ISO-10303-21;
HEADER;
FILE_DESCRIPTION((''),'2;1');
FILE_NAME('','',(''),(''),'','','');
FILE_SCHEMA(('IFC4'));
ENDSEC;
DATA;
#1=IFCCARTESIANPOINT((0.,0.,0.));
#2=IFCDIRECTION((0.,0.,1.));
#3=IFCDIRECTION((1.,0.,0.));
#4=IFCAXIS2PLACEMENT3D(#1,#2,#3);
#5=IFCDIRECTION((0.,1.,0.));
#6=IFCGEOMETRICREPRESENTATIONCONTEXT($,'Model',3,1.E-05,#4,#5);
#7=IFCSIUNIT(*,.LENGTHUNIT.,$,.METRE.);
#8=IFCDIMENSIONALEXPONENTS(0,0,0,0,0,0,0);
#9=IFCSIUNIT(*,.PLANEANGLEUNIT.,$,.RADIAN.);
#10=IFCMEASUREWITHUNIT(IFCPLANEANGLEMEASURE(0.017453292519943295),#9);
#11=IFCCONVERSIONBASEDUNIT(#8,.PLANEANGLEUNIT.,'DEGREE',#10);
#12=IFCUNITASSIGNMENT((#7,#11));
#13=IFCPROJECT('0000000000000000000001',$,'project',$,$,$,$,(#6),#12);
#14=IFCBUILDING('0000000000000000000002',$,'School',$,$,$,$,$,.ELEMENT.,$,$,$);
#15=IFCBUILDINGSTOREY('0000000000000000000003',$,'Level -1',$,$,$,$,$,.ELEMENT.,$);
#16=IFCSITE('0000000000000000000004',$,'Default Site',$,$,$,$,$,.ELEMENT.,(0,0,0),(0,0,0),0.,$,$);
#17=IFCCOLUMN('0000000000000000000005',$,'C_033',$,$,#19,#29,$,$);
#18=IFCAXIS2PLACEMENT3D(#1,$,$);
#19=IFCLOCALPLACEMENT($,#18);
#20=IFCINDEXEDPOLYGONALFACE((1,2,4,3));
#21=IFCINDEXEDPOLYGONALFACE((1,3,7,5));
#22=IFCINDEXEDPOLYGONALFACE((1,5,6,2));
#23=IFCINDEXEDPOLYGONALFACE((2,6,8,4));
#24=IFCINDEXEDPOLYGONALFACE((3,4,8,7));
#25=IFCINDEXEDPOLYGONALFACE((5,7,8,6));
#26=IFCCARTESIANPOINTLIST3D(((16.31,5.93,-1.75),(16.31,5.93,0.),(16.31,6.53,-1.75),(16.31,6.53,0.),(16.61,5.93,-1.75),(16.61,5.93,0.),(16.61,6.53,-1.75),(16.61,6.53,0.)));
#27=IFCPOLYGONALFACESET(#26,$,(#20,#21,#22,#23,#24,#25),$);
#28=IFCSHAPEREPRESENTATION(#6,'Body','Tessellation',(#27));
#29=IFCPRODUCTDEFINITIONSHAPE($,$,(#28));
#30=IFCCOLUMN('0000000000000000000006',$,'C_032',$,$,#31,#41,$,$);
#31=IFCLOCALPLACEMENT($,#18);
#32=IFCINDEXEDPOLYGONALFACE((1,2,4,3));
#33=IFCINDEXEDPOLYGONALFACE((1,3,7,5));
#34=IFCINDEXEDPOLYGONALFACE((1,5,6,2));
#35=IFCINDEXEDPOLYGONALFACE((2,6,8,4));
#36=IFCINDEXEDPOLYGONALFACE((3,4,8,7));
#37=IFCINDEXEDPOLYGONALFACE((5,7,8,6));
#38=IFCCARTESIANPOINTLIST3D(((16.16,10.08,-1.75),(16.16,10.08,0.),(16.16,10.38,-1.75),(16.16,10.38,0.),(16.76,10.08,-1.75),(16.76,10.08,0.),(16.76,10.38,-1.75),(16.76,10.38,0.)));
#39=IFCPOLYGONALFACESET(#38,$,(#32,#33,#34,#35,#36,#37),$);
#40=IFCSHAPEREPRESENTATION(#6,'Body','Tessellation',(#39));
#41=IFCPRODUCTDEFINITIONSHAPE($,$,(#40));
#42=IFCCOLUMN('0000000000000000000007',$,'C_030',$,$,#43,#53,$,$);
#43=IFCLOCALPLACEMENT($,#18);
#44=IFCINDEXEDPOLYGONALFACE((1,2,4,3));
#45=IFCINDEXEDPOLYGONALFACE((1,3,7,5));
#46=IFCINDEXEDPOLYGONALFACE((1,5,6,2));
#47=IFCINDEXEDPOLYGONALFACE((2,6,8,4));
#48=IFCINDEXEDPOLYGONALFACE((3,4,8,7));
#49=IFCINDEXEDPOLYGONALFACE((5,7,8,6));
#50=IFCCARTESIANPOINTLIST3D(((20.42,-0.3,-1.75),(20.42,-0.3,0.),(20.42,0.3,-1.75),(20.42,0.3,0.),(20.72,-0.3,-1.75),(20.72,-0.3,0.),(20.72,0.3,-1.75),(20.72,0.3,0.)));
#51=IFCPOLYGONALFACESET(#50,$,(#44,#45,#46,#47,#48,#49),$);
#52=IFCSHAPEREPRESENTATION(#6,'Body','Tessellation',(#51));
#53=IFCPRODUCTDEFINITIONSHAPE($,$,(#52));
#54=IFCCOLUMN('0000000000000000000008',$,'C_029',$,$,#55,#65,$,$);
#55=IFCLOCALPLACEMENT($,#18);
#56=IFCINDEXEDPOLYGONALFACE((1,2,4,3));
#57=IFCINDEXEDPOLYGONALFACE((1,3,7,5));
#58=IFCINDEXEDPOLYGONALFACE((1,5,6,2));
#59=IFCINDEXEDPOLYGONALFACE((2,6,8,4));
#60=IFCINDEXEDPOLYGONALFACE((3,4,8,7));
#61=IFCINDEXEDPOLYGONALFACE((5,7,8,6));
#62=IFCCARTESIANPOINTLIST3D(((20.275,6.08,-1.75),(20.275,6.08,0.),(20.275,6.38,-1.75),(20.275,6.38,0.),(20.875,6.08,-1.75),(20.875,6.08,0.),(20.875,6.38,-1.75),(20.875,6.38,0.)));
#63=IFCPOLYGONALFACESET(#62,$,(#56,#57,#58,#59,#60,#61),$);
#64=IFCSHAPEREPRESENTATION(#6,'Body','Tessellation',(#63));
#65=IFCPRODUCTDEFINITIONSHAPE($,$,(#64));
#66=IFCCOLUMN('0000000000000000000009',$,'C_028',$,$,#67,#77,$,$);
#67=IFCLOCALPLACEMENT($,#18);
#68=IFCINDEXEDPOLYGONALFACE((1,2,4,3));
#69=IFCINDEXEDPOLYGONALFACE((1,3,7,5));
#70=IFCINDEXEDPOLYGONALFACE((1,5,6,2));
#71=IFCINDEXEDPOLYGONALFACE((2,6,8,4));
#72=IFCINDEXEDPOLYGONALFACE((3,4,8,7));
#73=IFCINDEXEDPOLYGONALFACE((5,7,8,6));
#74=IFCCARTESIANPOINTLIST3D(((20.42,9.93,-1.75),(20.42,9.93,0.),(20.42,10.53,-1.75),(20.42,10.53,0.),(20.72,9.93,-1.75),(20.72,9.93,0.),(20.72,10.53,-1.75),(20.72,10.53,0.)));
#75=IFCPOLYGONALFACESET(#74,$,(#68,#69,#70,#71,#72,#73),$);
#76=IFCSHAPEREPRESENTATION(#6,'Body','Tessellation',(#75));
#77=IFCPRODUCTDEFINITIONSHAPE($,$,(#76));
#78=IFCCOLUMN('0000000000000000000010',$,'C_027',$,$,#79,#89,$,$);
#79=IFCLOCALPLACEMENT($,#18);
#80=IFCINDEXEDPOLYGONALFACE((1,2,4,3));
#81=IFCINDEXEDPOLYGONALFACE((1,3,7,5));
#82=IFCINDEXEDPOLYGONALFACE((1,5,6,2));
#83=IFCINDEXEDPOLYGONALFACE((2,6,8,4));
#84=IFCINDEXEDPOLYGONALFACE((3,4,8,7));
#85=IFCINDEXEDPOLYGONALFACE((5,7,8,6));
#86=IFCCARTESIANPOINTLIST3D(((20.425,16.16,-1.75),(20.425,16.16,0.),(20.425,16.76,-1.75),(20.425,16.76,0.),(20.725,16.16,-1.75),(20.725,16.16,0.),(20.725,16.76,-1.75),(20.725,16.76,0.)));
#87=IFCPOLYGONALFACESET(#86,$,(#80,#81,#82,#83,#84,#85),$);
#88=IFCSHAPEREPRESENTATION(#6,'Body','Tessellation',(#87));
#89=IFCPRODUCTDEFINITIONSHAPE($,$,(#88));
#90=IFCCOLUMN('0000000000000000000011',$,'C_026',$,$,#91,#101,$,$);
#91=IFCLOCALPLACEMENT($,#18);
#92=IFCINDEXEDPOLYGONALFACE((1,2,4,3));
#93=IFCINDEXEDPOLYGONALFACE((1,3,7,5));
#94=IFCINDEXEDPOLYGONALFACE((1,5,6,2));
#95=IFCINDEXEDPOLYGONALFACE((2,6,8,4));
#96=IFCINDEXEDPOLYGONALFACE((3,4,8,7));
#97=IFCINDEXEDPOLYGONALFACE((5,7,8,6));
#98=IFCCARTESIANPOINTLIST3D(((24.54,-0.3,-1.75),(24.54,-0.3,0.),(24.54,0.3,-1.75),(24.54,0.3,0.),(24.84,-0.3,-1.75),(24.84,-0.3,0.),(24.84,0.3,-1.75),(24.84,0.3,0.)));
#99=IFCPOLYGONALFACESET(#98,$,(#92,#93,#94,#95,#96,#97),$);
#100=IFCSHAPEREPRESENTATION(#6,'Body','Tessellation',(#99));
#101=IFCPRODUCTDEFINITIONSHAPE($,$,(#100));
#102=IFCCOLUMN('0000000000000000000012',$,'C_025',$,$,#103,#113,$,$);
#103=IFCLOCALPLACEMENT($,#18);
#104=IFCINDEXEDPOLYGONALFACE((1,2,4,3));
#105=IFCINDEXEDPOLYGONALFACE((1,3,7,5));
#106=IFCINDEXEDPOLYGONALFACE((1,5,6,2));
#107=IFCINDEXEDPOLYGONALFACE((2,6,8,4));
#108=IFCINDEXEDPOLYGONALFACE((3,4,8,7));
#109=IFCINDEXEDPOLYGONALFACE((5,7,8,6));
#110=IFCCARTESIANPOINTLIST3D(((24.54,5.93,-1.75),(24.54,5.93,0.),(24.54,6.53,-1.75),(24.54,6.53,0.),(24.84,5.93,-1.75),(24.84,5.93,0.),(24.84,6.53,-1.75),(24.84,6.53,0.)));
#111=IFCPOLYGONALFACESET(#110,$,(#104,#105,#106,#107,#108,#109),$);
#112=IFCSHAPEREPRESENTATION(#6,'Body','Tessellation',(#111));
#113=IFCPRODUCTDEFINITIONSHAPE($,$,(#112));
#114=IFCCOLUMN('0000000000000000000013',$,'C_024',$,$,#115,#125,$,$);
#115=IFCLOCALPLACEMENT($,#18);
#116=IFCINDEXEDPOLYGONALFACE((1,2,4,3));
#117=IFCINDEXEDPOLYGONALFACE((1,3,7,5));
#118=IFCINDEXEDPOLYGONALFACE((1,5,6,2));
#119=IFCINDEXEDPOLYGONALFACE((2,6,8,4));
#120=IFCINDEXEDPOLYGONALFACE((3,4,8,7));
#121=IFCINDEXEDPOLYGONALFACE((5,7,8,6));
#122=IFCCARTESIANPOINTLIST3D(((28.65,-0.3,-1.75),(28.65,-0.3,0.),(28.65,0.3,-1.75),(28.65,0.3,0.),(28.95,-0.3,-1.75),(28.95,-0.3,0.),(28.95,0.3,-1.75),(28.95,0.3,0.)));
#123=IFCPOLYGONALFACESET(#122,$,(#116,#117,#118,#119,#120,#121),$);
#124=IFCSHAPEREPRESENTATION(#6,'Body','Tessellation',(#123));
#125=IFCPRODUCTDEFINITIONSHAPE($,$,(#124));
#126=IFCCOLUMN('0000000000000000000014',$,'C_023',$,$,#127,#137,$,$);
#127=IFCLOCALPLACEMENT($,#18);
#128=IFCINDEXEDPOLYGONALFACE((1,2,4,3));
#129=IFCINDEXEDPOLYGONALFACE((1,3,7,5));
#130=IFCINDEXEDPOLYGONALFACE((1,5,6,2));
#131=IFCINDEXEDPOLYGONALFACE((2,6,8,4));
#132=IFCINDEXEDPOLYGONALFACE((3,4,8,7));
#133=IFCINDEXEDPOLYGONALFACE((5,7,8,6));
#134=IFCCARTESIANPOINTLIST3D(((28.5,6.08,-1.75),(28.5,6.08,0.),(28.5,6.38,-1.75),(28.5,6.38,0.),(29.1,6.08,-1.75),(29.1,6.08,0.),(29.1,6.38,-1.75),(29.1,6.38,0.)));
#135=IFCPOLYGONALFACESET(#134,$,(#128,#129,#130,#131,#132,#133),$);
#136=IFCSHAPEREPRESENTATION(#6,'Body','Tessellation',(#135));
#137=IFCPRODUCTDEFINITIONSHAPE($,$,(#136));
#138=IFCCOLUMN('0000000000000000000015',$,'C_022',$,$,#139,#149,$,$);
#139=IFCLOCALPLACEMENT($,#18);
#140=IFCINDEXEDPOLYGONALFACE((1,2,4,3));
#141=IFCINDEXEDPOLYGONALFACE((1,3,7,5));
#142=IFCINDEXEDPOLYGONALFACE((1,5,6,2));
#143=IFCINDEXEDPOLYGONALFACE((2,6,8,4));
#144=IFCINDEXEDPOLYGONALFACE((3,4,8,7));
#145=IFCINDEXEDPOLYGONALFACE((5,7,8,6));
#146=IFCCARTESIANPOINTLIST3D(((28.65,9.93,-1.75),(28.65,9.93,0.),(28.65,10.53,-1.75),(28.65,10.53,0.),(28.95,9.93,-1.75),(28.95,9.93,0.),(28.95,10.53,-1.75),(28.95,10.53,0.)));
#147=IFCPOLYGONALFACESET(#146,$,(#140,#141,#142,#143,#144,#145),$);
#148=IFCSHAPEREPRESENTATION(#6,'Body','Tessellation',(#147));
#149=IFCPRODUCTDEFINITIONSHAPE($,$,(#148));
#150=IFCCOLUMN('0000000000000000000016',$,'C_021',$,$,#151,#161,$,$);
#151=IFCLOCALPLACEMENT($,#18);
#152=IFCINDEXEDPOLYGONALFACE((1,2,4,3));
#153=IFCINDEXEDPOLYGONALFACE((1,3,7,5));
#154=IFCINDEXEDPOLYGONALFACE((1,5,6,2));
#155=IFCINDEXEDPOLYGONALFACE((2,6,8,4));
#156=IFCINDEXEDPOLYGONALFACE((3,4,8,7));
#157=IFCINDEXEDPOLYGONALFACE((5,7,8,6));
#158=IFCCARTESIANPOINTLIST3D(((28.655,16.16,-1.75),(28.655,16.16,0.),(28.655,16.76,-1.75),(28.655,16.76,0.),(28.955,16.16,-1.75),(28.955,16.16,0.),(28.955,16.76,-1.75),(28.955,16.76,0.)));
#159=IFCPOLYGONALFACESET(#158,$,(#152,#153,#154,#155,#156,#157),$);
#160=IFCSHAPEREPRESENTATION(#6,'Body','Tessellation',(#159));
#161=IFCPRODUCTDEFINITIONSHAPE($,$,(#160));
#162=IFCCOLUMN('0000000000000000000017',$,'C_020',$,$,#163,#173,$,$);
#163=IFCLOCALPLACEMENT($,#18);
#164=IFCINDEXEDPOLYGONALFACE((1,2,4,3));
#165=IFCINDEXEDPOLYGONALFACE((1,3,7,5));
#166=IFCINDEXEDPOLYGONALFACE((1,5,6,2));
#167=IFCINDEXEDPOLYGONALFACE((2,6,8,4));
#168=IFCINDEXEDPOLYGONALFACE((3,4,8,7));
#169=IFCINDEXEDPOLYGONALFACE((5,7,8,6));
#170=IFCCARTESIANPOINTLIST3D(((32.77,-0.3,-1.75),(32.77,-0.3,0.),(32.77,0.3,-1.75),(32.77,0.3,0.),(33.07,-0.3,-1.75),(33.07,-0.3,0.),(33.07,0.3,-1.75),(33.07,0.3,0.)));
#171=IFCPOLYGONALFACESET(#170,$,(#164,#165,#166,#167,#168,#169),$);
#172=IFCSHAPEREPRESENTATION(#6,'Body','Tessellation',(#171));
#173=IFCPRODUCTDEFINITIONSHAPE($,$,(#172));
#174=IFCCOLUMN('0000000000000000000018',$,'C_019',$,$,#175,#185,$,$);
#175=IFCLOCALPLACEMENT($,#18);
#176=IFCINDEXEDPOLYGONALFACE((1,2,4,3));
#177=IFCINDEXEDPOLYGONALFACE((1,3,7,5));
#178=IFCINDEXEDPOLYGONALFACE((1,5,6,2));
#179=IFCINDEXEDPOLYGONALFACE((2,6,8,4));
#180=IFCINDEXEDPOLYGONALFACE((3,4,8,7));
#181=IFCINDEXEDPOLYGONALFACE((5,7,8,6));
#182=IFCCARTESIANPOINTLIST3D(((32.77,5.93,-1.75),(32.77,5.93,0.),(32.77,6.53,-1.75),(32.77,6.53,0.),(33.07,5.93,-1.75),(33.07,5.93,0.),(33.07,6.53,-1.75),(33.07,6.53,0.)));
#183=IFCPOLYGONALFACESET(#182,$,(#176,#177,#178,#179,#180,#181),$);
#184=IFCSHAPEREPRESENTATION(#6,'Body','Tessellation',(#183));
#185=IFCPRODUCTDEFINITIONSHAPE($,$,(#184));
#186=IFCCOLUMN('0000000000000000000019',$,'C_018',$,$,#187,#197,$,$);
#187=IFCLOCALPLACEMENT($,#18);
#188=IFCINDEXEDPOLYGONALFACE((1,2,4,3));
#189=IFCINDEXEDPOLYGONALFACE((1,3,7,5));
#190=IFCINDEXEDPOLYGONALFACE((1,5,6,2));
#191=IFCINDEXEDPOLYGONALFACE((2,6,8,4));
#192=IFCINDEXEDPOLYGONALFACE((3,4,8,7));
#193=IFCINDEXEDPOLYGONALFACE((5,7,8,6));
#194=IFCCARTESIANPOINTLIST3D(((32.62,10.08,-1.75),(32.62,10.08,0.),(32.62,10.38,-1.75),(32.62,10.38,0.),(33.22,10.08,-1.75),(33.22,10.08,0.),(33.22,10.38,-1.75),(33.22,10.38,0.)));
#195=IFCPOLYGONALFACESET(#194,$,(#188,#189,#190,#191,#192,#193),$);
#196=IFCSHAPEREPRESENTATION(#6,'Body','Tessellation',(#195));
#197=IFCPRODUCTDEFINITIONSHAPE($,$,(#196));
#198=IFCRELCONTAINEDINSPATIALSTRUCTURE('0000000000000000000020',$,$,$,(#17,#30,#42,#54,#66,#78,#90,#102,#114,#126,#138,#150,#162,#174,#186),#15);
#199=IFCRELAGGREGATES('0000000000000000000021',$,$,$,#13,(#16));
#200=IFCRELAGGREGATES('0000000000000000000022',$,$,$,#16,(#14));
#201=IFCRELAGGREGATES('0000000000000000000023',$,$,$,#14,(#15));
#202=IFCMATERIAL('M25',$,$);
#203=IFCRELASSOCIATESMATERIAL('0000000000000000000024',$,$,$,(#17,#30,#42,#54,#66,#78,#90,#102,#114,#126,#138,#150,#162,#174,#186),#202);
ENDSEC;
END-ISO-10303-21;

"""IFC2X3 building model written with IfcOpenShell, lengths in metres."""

from ifc_helpers import new_model, entity, si_unit, converted_unit, direction, frame, frame_2d, origin_with_axes, place, context, project, spatial, rectangle, extrude, material, element, save


model = new_model("IFC2X3")

# Units and contexts
model_context = context("Model", 3, precision=1e-05, world=origin_with_axes(), true_north=direction((0.0, 1.0, 0.0)))
ifc_project = project(units=[si_unit("LENGTHUNIT", "METRE"), converted_unit("PLANEANGLEUNIT", "DEGREE", entity("IfcPlaneAngleMeasure", 0.017453292519943295), si_unit("PLANEANGLEUNIT", "RADIAN"), dimensions=[0, 0, 0, 0, 0, 0, 0])], contexts=[model_context])

# Site, building, storey
site = spatial("IfcSite", under=ifc_project, Name="Default Site", CompositionType="ELEMENT", RefLatitude=(0, 0, 0), RefLongitude=(0, 0, 0), RefElevation=0.0)
building = spatial("IfcBuilding", under=site, Name="School", CompositionType="ELEMENT")
storey = spatial("IfcBuildingStorey", under=building, Name="Level -1", CompositionType="ELEMENT")

# Columns
ifc_material = material(Name="M25")
placement = place(None, origin_with_axes())
element("IfcColumn", 1, at=placement, inside=storey, material=ifc_material, Name="C_033", context=model_context, shape_type="SweptSolid", body=[
    extrude(rectangle(XDim=0.3, YDim=0.6, at=frame_2d((0.0, 0.0), x_axis=(1.0, 0.0, 0.0))), frame((16.46, 6.23, -1.75), z_axis=(0.0, 0.0, 1.0), x_axis=(1.0, 0.0, 0.0)), (0.0, 0.0, 1.0), 1.75),
])
element("IfcColumn", 2, at=placement, inside=storey, material=ifc_material, Name="C_032", context=model_context, shape_type="SweptSolid", body=[
    extrude(rectangle(XDim=0.6, YDim=0.3, at=frame_2d((0.0, 0.0), x_axis=(1.0, 0.0, 0.0))), frame((16.46, 10.23, -1.75), z_axis=(0.0, 0.0, 1.0), x_axis=(1.0, 0.0, 0.0)), (0.0, 0.0, 1.0), 1.75),
])
element("IfcColumn", 3, at=placement, inside=storey, material=ifc_material, Name="C_030", context=model_context, shape_type="SweptSolid", body=[
    extrude(rectangle(XDim=0.3, YDim=0.6, at=frame_2d((0.0, 0.0), x_axis=(1.0, 0.0, 0.0))), frame((20.57, 0.0, -1.75), z_axis=(0.0, 0.0, 1.0), x_axis=(1.0, 0.0, 0.0)), (0.0, 0.0, 1.0), 1.75),
])
element("IfcColumn", 4, at=placement, inside=storey, material=ifc_material, Name="C_029", context=model_context, shape_type="SweptSolid", body=[
    extrude(rectangle(XDim=0.6, YDim=0.3, at=frame_2d((0.0, 0.0), x_axis=(1.0, 0.0, 0.0))), frame((20.575, 6.23, -1.75), z_axis=(0.0, 0.0, 1.0), x_axis=(1.0, 0.0, 0.0)), (0.0, 0.0, 1.0), 1.75),
])
element("IfcColumn", 5, at=placement, inside=storey, material=ifc_material, Name="C_028", context=model_context, shape_type="SweptSolid", body=[
    extrude(rectangle(XDim=0.3, YDim=0.6, at=frame_2d((0.0, 0.0), x_axis=(1.0, 0.0, 0.0))), frame((20.57, 10.23, -1.75), z_axis=(0.0, 0.0, 1.0), x_axis=(1.0, 0.0, 0.0)), (0.0, 0.0, 1.0), 1.75),
])
element("IfcColumn", 6, at=placement, inside=storey, material=ifc_material, Name="C_027", context=model_context, shape_type="SweptSolid", body=[
    extrude(rectangle(XDim=0.3, YDim=0.6, at=frame_2d((0.0, 0.0), x_axis=(1.0, 0.0, 0.0))), frame((20.575, 16.46, -1.75), z_axis=(0.0, 0.0, 1.0), x_axis=(1.0, 0.0, 0.0)), (0.0, 0.0, 1.0), 1.75),
])
element("IfcColumn", 7, at=placement, inside=storey, material=ifc_material, Name="C_026", context=model_context, shape_type="SweptSolid", body=[
    extrude(rectangle(XDim=0.3, YDim=0.6, at=frame_2d((0.0, 0.0), x_axis=(1.0, 0.0, 0.0))), frame((24.69, 0.0, -1.75), z_axis=(0.0, 0.0, 1.0), x_axis=(1.0, 0.0, 0.0)), (0.0, 0.0, 1.0), 1.75),
])
element("IfcColumn", 8, at=placement, inside=storey, material=ifc_material, Name="C_025", context=model_context, shape_type="SweptSolid", body=[
    extrude(rectangle(XDim=0.3, YDim=0.6, at=frame_2d((0.0, 0.0), x_axis=(1.0, 0.0, 0.0))), frame((24.69, 6.23, -1.75), z_axis=(0.0, 0.0, 1.0), x_axis=(1.0, 0.0, 0.0)), (0.0, 0.0, 1.0), 1.75),
])
element("IfcColumn", 9, at=placement, inside=storey, material=ifc_material, Name="C_024", context=model_context, shape_type="SweptSolid", body=[
    extrude(rectangle(XDim=0.3, YDim=0.6, at=frame_2d((0.0, 0.0), x_axis=(1.0, 0.0, 0.0))), frame((28.8, 0.0, -1.75), z_axis=(0.0, 0.0, 1.0), x_axis=(1.0, 0.0, 0.0)), (0.0, 0.0, 1.0), 1.75),
])
element("IfcColumn", 10, at=placement, inside=storey, material=ifc_material, Name="C_023", context=model_context, shape_type="SweptSolid", body=[
    extrude(rectangle(XDim=0.6, YDim=0.3, at=frame_2d((0.0, 0.0), x_axis=(1.0, 0.0, 0.0))), frame((28.8, 6.23, -1.75), z_axis=(0.0, 0.0, 1.0), x_axis=(1.0, 0.0, 0.0)), (0.0, 0.0, 1.0), 1.75),
])
element("IfcColumn", 11, at=placement, inside=storey, material=ifc_material, Name="C_022", context=model_context, shape_type="SweptSolid", body=[
    extrude(rectangle(XDim=0.3, YDim=0.6, at=frame_2d((0.0, 0.0), x_axis=(1.0, 0.0, 0.0))), frame((28.8, 10.23, -1.75), z_axis=(0.0, 0.0, 1.0), x_axis=(1.0, 0.0, 0.0)), (0.0, 0.0, 1.0), 1.75),
])
element("IfcColumn", 12, at=placement, inside=storey, material=ifc_material, Name="C_021", context=model_context, shape_type="SweptSolid", body=[
    extrude(rectangle(XDim=0.3, YDim=0.6, at=frame_2d((0.0, 0.0), x_axis=(1.0, 0.0, 0.0))), frame((28.805, 16.46, -1.75), z_axis=(0.0, 0.0, 1.0), x_axis=(1.0, 0.0, 0.0)), (0.0, 0.0, 1.0), 1.75),
])
element("IfcColumn", 13, at=placement, inside=storey, material=ifc_material, Name="C_020", context=model_context, shape_type="SweptSolid", body=[
    extrude(rectangle(XDim=0.3, YDim=0.6, at=frame_2d((0.0, 0.0), x_axis=(1.0, 0.0, 0.0))), frame((32.92, 0.0, -1.75), z_axis=(0.0, 0.0, 1.0), x_axis=(1.0, 0.0, 0.0)), (0.0, 0.0, 1.0), 1.75),
])
element("IfcColumn", 14, at=placement, inside=storey, material=ifc_material, Name="C_019", context=model_context, shape_type="SweptSolid", body=[
    extrude(rectangle(XDim=0.3, YDim=0.6, at=frame_2d((0.0, 0.0), x_axis=(1.0, 0.0, 0.0))), frame((32.92, 6.23, -1.75), z_axis=(0.0, 0.0, 1.0), x_axis=(1.0, 0.0, 0.0)), (0.0, 0.0, 1.0), 1.75),
])
element("IfcColumn", 15, at=placement, inside=storey, material=ifc_material, Name="C_018", context=model_context, shape_type="SweptSolid", body=[
    extrude(rectangle(XDim=0.6, YDim=0.3, at=frame_2d((0.0, 0.0), x_axis=(1.0, 0.0, 0.0))), frame((32.92, 10.23, -1.75), z_axis=(0.0, 0.0, 1.0), x_axis=(1.0, 0.0, 0.0)), (0.0, 0.0, 1.0), 1.75),
])

save(model, "model.ifc")
